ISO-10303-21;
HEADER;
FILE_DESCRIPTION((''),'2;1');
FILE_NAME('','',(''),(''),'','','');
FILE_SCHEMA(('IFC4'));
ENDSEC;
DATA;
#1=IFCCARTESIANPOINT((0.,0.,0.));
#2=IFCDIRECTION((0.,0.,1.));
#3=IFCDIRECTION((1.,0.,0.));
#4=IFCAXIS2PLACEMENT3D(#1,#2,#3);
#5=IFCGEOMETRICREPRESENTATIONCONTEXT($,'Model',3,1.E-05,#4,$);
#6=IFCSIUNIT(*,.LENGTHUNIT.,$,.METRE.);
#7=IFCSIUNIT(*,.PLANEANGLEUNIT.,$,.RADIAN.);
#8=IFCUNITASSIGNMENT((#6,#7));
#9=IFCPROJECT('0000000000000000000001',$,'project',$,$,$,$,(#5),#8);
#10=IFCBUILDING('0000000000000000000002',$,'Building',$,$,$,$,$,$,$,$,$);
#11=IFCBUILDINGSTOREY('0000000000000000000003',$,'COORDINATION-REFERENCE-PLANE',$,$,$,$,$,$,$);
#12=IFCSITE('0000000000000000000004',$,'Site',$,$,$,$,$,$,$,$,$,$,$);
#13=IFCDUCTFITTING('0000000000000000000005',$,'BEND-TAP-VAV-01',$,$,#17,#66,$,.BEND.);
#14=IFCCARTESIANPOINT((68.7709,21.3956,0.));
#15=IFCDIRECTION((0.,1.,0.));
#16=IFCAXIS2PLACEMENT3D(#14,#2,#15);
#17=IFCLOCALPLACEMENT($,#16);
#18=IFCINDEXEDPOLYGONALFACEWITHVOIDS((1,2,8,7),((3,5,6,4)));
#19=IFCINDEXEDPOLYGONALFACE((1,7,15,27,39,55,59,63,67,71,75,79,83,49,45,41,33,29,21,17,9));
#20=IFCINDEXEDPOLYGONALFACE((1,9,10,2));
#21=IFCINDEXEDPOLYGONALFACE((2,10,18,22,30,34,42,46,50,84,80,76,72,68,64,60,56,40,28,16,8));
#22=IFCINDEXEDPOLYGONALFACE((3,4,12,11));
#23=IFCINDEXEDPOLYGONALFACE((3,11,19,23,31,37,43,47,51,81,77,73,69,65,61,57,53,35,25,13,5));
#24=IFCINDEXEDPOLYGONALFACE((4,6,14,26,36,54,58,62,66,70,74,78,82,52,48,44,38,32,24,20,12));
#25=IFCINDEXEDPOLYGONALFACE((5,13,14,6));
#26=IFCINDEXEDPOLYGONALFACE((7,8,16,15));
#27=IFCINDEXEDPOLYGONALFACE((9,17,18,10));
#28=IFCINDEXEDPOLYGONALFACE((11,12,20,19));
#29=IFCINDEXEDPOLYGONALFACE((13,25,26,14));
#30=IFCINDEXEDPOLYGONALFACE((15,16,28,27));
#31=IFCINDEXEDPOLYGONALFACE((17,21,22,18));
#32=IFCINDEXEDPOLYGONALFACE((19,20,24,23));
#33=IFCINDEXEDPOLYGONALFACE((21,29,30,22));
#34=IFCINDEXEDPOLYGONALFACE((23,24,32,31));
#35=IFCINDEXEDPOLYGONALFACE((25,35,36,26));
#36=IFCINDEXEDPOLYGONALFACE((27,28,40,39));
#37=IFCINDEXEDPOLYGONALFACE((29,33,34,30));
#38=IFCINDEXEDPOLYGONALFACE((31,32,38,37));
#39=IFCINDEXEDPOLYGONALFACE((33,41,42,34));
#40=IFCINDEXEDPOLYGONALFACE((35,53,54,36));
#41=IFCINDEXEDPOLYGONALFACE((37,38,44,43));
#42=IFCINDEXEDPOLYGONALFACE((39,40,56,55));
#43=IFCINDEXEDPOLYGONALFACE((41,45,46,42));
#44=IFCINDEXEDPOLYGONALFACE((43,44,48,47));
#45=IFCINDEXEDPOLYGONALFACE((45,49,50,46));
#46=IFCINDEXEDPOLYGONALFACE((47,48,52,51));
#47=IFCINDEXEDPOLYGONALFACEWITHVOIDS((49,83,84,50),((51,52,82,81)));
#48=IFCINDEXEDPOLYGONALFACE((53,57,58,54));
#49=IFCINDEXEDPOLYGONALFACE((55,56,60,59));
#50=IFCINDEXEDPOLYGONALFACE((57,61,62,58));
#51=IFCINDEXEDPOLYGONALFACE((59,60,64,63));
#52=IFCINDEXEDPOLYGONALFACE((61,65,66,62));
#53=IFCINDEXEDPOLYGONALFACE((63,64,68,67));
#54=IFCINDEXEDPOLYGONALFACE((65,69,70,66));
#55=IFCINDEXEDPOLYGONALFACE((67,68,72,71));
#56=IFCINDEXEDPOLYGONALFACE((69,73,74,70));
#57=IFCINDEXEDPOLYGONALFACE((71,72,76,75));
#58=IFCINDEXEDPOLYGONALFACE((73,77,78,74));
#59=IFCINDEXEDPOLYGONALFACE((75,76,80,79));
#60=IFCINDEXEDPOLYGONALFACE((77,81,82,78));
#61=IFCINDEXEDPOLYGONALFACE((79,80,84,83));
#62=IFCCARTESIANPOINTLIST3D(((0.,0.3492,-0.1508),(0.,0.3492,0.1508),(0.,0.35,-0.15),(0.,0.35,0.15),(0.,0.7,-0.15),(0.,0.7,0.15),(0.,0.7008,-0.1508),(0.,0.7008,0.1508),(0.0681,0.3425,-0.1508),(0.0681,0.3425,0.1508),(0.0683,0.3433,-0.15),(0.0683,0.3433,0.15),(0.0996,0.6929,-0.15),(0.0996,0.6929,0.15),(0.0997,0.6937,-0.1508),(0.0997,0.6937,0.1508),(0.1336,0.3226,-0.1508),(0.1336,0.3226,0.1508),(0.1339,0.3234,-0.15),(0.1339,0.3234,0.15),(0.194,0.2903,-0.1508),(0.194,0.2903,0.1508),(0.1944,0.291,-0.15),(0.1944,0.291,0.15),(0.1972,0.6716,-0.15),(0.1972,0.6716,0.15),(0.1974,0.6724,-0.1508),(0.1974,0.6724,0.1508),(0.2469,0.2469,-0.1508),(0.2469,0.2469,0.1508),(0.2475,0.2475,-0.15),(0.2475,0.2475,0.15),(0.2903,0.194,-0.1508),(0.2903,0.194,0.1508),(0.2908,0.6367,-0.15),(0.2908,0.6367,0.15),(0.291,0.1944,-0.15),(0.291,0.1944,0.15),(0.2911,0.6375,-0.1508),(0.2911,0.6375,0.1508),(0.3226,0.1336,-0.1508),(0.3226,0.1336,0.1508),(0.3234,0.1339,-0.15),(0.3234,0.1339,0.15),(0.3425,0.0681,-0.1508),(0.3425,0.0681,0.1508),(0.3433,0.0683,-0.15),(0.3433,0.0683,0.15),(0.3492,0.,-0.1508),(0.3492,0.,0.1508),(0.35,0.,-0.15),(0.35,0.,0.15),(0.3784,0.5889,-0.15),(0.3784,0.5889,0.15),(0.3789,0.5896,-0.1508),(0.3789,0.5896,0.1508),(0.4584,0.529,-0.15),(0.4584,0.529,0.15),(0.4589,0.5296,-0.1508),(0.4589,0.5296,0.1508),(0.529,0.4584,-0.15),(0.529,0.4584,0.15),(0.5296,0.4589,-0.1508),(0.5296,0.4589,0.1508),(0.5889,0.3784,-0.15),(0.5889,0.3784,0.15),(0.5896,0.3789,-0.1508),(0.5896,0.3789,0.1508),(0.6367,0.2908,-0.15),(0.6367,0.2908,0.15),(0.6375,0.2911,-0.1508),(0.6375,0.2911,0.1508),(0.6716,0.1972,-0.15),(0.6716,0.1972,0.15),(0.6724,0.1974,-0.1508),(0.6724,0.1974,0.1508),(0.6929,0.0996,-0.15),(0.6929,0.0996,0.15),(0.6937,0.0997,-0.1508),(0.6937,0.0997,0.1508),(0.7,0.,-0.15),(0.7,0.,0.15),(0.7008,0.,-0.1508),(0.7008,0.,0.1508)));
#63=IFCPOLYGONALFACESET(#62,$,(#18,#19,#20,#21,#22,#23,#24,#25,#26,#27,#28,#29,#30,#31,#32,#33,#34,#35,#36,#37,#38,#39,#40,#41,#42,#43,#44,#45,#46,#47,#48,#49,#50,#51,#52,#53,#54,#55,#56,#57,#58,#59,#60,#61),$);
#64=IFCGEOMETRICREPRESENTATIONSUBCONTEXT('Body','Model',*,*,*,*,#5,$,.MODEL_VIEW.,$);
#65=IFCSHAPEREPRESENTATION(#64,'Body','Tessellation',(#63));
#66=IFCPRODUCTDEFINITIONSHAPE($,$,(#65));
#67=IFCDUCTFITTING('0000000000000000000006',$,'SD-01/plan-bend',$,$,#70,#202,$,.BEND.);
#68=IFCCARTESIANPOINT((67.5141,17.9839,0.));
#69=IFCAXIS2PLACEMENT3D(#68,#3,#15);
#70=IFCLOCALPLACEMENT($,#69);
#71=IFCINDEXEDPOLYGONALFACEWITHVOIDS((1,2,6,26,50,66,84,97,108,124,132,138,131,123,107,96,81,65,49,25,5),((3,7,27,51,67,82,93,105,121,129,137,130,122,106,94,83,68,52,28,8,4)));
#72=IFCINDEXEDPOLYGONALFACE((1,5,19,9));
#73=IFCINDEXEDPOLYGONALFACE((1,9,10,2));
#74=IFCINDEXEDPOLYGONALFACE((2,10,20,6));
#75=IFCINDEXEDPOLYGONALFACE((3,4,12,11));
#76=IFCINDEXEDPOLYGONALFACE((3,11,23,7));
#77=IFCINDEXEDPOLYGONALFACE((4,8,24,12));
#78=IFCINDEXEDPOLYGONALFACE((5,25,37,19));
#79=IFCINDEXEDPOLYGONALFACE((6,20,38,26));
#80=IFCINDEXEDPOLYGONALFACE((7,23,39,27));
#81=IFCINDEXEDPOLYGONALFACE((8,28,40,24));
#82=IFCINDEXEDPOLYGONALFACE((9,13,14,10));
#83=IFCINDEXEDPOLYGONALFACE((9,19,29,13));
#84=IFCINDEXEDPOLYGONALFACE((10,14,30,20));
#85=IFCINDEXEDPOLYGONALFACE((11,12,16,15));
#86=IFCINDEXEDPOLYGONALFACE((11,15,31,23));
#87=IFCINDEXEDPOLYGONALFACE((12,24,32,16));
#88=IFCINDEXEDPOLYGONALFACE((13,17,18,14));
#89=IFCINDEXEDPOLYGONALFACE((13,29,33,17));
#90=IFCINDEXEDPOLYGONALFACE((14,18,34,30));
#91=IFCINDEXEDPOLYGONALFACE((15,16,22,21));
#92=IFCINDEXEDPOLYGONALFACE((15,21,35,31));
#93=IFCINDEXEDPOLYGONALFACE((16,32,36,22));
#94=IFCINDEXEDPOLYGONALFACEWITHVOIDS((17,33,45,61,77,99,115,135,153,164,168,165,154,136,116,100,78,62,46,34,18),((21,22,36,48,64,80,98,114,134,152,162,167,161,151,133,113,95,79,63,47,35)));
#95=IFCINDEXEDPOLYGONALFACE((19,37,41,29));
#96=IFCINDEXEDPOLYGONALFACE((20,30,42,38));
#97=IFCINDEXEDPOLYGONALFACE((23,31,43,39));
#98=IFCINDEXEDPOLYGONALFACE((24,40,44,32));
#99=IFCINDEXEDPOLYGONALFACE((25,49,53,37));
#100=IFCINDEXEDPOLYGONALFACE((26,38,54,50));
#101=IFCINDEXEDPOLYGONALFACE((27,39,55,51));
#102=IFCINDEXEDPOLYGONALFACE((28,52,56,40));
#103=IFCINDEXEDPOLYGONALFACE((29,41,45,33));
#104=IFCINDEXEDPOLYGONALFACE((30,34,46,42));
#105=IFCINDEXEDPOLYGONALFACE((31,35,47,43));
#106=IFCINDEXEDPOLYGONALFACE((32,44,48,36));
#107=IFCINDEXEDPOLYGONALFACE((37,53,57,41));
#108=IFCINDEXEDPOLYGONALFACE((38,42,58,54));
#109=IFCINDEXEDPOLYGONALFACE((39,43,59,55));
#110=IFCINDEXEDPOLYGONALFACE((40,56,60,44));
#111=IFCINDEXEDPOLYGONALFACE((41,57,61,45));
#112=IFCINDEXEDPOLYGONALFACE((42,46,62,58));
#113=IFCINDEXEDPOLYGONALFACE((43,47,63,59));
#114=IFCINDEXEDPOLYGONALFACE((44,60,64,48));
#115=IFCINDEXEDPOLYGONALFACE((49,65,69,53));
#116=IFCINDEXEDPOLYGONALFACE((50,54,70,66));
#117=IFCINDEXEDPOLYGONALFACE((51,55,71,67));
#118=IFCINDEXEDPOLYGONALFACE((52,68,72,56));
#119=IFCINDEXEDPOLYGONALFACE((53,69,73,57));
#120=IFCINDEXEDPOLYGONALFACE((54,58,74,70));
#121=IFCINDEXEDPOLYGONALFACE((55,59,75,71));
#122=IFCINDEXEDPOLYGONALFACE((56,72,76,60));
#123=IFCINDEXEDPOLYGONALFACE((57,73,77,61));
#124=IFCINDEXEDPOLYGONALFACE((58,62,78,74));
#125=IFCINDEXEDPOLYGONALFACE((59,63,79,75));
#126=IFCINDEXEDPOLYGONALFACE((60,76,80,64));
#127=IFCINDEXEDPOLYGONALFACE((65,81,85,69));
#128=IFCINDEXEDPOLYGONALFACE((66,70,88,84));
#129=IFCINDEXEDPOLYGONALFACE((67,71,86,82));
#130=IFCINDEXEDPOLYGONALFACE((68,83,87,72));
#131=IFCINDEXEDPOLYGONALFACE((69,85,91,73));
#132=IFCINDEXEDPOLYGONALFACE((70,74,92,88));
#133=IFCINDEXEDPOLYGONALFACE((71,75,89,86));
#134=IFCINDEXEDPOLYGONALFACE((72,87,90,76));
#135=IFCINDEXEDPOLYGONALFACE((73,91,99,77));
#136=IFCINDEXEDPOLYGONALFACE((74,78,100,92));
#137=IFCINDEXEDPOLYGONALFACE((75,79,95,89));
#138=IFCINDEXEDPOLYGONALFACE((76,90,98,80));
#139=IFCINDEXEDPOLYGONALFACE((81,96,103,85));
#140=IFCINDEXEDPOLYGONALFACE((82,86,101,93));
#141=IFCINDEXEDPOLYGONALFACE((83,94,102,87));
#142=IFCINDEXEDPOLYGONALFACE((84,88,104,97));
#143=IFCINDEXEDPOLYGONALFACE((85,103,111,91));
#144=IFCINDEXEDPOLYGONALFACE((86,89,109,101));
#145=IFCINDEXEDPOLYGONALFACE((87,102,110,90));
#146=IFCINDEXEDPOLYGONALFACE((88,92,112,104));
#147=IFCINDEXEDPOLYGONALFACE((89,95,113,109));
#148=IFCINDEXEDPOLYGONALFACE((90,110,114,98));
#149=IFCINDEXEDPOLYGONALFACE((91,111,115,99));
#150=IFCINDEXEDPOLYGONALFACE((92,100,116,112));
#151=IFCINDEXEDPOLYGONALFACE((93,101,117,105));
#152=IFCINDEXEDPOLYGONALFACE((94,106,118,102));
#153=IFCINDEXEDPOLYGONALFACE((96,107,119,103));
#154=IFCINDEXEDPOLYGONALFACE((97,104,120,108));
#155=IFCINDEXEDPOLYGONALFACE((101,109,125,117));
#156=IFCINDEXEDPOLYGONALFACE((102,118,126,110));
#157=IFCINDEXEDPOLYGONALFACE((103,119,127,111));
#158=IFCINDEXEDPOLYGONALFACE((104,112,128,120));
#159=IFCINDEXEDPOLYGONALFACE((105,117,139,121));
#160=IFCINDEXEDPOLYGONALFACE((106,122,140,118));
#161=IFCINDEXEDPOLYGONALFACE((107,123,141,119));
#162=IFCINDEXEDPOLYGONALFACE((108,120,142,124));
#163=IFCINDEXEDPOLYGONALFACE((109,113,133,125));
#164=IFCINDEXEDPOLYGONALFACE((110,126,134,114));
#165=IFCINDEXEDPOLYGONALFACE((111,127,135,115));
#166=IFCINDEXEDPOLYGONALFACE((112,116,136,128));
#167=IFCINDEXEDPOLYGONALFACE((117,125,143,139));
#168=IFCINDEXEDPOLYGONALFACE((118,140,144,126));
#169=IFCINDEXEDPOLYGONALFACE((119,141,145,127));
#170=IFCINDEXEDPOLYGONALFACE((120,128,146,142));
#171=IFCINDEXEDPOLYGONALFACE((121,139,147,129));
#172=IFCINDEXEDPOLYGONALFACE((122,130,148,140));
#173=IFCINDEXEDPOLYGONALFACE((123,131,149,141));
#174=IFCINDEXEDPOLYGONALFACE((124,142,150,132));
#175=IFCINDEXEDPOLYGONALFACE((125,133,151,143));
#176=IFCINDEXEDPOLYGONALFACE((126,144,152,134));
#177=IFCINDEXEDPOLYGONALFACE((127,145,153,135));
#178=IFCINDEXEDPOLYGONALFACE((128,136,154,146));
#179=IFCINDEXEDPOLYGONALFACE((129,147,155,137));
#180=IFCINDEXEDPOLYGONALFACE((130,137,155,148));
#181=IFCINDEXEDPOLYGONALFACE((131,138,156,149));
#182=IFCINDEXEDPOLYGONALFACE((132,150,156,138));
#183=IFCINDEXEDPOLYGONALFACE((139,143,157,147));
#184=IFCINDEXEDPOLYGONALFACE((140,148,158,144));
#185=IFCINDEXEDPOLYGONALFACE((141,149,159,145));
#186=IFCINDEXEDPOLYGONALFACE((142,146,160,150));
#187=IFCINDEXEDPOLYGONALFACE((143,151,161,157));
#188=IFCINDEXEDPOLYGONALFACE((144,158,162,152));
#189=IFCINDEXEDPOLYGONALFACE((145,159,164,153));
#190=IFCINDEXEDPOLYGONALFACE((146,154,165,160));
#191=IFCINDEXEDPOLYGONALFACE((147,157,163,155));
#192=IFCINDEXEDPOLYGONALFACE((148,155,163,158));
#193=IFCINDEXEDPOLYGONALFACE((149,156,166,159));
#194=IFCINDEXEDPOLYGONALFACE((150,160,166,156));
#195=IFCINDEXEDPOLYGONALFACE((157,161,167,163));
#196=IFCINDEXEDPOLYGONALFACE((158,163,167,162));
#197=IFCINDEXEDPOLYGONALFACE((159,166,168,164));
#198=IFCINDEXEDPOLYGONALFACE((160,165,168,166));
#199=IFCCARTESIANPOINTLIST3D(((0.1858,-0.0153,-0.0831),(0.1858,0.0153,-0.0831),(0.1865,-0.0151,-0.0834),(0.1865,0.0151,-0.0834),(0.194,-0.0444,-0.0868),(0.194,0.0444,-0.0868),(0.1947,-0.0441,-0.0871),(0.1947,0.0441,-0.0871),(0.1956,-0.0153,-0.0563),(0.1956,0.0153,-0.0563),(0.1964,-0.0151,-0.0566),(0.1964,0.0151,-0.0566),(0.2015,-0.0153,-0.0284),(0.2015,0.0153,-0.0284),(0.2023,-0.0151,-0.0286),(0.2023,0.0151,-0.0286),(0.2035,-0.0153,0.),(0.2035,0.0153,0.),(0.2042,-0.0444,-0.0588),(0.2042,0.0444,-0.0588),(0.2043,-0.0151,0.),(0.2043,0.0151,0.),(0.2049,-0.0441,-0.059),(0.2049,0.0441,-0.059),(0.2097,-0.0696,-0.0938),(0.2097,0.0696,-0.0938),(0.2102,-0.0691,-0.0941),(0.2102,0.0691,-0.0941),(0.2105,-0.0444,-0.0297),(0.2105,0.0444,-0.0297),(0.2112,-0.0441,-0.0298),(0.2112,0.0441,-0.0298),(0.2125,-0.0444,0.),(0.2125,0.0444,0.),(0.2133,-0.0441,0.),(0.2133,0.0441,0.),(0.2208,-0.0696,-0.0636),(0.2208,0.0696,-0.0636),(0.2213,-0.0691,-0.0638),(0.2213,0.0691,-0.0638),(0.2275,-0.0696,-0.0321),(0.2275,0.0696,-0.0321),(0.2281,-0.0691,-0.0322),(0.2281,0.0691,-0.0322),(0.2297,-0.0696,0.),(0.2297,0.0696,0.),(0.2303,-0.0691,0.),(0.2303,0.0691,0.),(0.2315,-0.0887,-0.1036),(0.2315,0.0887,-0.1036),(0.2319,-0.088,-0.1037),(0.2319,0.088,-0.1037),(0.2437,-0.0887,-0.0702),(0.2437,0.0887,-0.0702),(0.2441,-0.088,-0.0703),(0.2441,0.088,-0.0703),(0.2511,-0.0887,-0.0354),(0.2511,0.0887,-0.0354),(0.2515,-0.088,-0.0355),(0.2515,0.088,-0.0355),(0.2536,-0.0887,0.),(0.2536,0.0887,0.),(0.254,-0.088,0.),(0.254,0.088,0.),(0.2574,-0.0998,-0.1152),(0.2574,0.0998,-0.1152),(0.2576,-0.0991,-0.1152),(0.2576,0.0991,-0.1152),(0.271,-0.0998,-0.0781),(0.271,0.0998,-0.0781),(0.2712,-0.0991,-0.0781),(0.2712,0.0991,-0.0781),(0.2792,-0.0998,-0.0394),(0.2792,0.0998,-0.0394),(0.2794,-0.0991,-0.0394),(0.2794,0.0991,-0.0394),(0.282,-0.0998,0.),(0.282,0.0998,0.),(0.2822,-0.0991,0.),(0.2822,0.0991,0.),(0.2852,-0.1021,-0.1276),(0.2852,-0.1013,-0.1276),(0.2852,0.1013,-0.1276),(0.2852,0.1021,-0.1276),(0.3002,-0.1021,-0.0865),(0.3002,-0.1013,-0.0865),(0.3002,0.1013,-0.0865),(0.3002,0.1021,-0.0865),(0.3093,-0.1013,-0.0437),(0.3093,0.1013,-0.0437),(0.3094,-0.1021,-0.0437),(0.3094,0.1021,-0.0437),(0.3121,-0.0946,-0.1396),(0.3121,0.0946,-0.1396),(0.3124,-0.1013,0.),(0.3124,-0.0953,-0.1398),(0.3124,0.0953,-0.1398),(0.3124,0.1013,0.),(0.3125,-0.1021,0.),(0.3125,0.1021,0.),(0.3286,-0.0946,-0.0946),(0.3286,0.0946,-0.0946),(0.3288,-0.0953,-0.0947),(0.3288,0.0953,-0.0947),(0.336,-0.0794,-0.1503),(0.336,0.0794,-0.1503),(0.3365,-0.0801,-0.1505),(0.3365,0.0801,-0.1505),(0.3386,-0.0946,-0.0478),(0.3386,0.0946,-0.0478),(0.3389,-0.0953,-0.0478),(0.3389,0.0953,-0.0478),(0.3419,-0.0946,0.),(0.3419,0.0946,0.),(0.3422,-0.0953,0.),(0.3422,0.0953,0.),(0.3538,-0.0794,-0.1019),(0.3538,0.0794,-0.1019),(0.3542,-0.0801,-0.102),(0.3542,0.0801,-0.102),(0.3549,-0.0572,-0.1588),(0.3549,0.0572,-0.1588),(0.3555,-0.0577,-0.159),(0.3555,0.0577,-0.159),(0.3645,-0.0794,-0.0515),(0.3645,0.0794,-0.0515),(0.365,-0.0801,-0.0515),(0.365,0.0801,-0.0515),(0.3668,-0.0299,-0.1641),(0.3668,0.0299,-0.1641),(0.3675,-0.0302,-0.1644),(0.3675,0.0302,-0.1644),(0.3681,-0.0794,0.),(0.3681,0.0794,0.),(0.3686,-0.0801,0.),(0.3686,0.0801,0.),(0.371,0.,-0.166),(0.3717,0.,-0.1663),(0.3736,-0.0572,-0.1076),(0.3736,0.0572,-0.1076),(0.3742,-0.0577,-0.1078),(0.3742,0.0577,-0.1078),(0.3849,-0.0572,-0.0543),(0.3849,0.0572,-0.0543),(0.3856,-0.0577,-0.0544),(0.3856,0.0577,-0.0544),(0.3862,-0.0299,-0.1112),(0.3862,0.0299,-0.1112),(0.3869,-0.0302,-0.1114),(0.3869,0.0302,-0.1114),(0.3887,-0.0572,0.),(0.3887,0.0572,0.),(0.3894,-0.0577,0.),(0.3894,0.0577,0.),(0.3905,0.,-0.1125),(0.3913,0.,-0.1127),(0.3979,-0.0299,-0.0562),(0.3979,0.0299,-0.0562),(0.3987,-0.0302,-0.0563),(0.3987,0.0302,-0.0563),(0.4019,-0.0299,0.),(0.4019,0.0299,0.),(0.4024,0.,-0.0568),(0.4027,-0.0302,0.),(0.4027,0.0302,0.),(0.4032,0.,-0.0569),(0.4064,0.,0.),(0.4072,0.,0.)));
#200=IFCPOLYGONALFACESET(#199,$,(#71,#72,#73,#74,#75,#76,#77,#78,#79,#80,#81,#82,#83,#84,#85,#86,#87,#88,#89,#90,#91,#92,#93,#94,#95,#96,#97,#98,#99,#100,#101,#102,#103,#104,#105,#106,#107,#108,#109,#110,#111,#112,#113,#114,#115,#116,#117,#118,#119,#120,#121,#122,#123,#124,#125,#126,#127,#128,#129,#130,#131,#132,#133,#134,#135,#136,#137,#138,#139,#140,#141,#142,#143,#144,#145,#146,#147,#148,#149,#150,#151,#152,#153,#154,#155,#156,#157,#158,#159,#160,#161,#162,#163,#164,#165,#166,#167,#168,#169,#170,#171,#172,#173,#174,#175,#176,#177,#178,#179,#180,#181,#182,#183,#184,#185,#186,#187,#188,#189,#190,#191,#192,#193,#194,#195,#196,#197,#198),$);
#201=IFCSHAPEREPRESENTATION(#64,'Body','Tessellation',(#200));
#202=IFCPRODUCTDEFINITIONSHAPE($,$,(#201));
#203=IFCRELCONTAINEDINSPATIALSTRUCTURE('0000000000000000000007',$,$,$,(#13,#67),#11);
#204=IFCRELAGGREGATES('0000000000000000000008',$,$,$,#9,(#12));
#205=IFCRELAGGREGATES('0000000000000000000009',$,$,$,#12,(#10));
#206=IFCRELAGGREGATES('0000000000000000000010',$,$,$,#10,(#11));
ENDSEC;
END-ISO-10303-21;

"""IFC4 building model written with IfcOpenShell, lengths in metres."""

from ifc_helpers import new_model, entity, si_unit, frame, origin_with_axes, place, context, subcontext, project, spatial, element, save


model = new_model("IFC4")

# Units and contexts
model_context = context("Model", 3, precision=1e-05, world=origin_with_axes())
body_context_1 = subcontext(model_context, "Body", "Model", "MODEL_VIEW")
ifc_project = project(units=[si_unit("LENGTHUNIT", "METRE"), si_unit("PLANEANGLEUNIT", "RADIAN")], contexts=[model_context])

# Site, building, storey
site = spatial("IfcSite", under=ifc_project, Name="Site")
building = spatial("IfcBuilding", under=site, Name="Building")
storey = spatial("IfcBuildingStorey", under=building, Name="COORDINATION-REFERENCE-PLANE")

# Duct fitting
duct_fitting_1_placement = place(None, frame((68.7709, 21.3956, 0.0), z_axis=(0.0, 0.0, 1.0), x_axis=(0.0, 1.0, 0.0)))
cartesian_point = entity("IfcCartesianPoint", [0.0, 0.0, 0.0])
element("IfcDuctFitting", 1, at=duct_fitting_1_placement, inside=storey, Name="BEND-TAP-VAV-01", PredefinedType="BEND", context=body_context_1, shape_type="SweptSolid", body=[
    entity("IfcRevolvedAreaSolid", entity("IfcRectangleHollowProfileDef", "AREA", None, entity("IfcAxis2Placement2D", entity("IfcCartesianPoint", [0.525, 0.0])), 0.3516, 0.3016, 0.0008), entity("IfcAxis2Placement3D", cartesian_point, entity("IfcDirection", [0.0, -1.0, 0.0]), entity("IfcDirection", [1.0, 0.0, 0.0])), entity("IfcAxis1Placement", cartesian_point, entity("IfcDirection", [0.0, 1.0, 0.0])), 1.570796),
])

# Duct fitting
duct_fitting_2_placement = place(None, frame((67.5141, 17.9839, 0.0), z_axis=(1.0, 0.0, 0.0), x_axis=(0.0, 1.0, 0.0)))
element("IfcDuctFitting", 2, at=duct_fitting_2_placement, inside=storey, Name="SD-01/plan-bend", PredefinedType="BEND", context=body_context_1, shape_type="SweptSolid", body=[
    entity("IfcRevolvedAreaSolid", entity("IfcCircleHollowProfileDef", "AREA", None, entity("IfcAxis2Placement2D", entity("IfcCartesianPoint", [0.3048, 0.0])), 0.1024, 0.0008), entity("IfcAxis2Placement3D", entity("IfcCartesianPoint", [0.0, 0.0, 0.0]), entity("IfcDirection", [0.0, 0.0, 1.0]), entity("IfcDirection", [1.0, 0.0, 0.0])), entity("IfcAxis1Placement", entity("IfcCartesianPoint", [0.0, 0.0, 0.0]), entity("IfcDirection", [0.0, 1.0, 0.0])), 0.420676),
])

save(model, "model.ifc")
